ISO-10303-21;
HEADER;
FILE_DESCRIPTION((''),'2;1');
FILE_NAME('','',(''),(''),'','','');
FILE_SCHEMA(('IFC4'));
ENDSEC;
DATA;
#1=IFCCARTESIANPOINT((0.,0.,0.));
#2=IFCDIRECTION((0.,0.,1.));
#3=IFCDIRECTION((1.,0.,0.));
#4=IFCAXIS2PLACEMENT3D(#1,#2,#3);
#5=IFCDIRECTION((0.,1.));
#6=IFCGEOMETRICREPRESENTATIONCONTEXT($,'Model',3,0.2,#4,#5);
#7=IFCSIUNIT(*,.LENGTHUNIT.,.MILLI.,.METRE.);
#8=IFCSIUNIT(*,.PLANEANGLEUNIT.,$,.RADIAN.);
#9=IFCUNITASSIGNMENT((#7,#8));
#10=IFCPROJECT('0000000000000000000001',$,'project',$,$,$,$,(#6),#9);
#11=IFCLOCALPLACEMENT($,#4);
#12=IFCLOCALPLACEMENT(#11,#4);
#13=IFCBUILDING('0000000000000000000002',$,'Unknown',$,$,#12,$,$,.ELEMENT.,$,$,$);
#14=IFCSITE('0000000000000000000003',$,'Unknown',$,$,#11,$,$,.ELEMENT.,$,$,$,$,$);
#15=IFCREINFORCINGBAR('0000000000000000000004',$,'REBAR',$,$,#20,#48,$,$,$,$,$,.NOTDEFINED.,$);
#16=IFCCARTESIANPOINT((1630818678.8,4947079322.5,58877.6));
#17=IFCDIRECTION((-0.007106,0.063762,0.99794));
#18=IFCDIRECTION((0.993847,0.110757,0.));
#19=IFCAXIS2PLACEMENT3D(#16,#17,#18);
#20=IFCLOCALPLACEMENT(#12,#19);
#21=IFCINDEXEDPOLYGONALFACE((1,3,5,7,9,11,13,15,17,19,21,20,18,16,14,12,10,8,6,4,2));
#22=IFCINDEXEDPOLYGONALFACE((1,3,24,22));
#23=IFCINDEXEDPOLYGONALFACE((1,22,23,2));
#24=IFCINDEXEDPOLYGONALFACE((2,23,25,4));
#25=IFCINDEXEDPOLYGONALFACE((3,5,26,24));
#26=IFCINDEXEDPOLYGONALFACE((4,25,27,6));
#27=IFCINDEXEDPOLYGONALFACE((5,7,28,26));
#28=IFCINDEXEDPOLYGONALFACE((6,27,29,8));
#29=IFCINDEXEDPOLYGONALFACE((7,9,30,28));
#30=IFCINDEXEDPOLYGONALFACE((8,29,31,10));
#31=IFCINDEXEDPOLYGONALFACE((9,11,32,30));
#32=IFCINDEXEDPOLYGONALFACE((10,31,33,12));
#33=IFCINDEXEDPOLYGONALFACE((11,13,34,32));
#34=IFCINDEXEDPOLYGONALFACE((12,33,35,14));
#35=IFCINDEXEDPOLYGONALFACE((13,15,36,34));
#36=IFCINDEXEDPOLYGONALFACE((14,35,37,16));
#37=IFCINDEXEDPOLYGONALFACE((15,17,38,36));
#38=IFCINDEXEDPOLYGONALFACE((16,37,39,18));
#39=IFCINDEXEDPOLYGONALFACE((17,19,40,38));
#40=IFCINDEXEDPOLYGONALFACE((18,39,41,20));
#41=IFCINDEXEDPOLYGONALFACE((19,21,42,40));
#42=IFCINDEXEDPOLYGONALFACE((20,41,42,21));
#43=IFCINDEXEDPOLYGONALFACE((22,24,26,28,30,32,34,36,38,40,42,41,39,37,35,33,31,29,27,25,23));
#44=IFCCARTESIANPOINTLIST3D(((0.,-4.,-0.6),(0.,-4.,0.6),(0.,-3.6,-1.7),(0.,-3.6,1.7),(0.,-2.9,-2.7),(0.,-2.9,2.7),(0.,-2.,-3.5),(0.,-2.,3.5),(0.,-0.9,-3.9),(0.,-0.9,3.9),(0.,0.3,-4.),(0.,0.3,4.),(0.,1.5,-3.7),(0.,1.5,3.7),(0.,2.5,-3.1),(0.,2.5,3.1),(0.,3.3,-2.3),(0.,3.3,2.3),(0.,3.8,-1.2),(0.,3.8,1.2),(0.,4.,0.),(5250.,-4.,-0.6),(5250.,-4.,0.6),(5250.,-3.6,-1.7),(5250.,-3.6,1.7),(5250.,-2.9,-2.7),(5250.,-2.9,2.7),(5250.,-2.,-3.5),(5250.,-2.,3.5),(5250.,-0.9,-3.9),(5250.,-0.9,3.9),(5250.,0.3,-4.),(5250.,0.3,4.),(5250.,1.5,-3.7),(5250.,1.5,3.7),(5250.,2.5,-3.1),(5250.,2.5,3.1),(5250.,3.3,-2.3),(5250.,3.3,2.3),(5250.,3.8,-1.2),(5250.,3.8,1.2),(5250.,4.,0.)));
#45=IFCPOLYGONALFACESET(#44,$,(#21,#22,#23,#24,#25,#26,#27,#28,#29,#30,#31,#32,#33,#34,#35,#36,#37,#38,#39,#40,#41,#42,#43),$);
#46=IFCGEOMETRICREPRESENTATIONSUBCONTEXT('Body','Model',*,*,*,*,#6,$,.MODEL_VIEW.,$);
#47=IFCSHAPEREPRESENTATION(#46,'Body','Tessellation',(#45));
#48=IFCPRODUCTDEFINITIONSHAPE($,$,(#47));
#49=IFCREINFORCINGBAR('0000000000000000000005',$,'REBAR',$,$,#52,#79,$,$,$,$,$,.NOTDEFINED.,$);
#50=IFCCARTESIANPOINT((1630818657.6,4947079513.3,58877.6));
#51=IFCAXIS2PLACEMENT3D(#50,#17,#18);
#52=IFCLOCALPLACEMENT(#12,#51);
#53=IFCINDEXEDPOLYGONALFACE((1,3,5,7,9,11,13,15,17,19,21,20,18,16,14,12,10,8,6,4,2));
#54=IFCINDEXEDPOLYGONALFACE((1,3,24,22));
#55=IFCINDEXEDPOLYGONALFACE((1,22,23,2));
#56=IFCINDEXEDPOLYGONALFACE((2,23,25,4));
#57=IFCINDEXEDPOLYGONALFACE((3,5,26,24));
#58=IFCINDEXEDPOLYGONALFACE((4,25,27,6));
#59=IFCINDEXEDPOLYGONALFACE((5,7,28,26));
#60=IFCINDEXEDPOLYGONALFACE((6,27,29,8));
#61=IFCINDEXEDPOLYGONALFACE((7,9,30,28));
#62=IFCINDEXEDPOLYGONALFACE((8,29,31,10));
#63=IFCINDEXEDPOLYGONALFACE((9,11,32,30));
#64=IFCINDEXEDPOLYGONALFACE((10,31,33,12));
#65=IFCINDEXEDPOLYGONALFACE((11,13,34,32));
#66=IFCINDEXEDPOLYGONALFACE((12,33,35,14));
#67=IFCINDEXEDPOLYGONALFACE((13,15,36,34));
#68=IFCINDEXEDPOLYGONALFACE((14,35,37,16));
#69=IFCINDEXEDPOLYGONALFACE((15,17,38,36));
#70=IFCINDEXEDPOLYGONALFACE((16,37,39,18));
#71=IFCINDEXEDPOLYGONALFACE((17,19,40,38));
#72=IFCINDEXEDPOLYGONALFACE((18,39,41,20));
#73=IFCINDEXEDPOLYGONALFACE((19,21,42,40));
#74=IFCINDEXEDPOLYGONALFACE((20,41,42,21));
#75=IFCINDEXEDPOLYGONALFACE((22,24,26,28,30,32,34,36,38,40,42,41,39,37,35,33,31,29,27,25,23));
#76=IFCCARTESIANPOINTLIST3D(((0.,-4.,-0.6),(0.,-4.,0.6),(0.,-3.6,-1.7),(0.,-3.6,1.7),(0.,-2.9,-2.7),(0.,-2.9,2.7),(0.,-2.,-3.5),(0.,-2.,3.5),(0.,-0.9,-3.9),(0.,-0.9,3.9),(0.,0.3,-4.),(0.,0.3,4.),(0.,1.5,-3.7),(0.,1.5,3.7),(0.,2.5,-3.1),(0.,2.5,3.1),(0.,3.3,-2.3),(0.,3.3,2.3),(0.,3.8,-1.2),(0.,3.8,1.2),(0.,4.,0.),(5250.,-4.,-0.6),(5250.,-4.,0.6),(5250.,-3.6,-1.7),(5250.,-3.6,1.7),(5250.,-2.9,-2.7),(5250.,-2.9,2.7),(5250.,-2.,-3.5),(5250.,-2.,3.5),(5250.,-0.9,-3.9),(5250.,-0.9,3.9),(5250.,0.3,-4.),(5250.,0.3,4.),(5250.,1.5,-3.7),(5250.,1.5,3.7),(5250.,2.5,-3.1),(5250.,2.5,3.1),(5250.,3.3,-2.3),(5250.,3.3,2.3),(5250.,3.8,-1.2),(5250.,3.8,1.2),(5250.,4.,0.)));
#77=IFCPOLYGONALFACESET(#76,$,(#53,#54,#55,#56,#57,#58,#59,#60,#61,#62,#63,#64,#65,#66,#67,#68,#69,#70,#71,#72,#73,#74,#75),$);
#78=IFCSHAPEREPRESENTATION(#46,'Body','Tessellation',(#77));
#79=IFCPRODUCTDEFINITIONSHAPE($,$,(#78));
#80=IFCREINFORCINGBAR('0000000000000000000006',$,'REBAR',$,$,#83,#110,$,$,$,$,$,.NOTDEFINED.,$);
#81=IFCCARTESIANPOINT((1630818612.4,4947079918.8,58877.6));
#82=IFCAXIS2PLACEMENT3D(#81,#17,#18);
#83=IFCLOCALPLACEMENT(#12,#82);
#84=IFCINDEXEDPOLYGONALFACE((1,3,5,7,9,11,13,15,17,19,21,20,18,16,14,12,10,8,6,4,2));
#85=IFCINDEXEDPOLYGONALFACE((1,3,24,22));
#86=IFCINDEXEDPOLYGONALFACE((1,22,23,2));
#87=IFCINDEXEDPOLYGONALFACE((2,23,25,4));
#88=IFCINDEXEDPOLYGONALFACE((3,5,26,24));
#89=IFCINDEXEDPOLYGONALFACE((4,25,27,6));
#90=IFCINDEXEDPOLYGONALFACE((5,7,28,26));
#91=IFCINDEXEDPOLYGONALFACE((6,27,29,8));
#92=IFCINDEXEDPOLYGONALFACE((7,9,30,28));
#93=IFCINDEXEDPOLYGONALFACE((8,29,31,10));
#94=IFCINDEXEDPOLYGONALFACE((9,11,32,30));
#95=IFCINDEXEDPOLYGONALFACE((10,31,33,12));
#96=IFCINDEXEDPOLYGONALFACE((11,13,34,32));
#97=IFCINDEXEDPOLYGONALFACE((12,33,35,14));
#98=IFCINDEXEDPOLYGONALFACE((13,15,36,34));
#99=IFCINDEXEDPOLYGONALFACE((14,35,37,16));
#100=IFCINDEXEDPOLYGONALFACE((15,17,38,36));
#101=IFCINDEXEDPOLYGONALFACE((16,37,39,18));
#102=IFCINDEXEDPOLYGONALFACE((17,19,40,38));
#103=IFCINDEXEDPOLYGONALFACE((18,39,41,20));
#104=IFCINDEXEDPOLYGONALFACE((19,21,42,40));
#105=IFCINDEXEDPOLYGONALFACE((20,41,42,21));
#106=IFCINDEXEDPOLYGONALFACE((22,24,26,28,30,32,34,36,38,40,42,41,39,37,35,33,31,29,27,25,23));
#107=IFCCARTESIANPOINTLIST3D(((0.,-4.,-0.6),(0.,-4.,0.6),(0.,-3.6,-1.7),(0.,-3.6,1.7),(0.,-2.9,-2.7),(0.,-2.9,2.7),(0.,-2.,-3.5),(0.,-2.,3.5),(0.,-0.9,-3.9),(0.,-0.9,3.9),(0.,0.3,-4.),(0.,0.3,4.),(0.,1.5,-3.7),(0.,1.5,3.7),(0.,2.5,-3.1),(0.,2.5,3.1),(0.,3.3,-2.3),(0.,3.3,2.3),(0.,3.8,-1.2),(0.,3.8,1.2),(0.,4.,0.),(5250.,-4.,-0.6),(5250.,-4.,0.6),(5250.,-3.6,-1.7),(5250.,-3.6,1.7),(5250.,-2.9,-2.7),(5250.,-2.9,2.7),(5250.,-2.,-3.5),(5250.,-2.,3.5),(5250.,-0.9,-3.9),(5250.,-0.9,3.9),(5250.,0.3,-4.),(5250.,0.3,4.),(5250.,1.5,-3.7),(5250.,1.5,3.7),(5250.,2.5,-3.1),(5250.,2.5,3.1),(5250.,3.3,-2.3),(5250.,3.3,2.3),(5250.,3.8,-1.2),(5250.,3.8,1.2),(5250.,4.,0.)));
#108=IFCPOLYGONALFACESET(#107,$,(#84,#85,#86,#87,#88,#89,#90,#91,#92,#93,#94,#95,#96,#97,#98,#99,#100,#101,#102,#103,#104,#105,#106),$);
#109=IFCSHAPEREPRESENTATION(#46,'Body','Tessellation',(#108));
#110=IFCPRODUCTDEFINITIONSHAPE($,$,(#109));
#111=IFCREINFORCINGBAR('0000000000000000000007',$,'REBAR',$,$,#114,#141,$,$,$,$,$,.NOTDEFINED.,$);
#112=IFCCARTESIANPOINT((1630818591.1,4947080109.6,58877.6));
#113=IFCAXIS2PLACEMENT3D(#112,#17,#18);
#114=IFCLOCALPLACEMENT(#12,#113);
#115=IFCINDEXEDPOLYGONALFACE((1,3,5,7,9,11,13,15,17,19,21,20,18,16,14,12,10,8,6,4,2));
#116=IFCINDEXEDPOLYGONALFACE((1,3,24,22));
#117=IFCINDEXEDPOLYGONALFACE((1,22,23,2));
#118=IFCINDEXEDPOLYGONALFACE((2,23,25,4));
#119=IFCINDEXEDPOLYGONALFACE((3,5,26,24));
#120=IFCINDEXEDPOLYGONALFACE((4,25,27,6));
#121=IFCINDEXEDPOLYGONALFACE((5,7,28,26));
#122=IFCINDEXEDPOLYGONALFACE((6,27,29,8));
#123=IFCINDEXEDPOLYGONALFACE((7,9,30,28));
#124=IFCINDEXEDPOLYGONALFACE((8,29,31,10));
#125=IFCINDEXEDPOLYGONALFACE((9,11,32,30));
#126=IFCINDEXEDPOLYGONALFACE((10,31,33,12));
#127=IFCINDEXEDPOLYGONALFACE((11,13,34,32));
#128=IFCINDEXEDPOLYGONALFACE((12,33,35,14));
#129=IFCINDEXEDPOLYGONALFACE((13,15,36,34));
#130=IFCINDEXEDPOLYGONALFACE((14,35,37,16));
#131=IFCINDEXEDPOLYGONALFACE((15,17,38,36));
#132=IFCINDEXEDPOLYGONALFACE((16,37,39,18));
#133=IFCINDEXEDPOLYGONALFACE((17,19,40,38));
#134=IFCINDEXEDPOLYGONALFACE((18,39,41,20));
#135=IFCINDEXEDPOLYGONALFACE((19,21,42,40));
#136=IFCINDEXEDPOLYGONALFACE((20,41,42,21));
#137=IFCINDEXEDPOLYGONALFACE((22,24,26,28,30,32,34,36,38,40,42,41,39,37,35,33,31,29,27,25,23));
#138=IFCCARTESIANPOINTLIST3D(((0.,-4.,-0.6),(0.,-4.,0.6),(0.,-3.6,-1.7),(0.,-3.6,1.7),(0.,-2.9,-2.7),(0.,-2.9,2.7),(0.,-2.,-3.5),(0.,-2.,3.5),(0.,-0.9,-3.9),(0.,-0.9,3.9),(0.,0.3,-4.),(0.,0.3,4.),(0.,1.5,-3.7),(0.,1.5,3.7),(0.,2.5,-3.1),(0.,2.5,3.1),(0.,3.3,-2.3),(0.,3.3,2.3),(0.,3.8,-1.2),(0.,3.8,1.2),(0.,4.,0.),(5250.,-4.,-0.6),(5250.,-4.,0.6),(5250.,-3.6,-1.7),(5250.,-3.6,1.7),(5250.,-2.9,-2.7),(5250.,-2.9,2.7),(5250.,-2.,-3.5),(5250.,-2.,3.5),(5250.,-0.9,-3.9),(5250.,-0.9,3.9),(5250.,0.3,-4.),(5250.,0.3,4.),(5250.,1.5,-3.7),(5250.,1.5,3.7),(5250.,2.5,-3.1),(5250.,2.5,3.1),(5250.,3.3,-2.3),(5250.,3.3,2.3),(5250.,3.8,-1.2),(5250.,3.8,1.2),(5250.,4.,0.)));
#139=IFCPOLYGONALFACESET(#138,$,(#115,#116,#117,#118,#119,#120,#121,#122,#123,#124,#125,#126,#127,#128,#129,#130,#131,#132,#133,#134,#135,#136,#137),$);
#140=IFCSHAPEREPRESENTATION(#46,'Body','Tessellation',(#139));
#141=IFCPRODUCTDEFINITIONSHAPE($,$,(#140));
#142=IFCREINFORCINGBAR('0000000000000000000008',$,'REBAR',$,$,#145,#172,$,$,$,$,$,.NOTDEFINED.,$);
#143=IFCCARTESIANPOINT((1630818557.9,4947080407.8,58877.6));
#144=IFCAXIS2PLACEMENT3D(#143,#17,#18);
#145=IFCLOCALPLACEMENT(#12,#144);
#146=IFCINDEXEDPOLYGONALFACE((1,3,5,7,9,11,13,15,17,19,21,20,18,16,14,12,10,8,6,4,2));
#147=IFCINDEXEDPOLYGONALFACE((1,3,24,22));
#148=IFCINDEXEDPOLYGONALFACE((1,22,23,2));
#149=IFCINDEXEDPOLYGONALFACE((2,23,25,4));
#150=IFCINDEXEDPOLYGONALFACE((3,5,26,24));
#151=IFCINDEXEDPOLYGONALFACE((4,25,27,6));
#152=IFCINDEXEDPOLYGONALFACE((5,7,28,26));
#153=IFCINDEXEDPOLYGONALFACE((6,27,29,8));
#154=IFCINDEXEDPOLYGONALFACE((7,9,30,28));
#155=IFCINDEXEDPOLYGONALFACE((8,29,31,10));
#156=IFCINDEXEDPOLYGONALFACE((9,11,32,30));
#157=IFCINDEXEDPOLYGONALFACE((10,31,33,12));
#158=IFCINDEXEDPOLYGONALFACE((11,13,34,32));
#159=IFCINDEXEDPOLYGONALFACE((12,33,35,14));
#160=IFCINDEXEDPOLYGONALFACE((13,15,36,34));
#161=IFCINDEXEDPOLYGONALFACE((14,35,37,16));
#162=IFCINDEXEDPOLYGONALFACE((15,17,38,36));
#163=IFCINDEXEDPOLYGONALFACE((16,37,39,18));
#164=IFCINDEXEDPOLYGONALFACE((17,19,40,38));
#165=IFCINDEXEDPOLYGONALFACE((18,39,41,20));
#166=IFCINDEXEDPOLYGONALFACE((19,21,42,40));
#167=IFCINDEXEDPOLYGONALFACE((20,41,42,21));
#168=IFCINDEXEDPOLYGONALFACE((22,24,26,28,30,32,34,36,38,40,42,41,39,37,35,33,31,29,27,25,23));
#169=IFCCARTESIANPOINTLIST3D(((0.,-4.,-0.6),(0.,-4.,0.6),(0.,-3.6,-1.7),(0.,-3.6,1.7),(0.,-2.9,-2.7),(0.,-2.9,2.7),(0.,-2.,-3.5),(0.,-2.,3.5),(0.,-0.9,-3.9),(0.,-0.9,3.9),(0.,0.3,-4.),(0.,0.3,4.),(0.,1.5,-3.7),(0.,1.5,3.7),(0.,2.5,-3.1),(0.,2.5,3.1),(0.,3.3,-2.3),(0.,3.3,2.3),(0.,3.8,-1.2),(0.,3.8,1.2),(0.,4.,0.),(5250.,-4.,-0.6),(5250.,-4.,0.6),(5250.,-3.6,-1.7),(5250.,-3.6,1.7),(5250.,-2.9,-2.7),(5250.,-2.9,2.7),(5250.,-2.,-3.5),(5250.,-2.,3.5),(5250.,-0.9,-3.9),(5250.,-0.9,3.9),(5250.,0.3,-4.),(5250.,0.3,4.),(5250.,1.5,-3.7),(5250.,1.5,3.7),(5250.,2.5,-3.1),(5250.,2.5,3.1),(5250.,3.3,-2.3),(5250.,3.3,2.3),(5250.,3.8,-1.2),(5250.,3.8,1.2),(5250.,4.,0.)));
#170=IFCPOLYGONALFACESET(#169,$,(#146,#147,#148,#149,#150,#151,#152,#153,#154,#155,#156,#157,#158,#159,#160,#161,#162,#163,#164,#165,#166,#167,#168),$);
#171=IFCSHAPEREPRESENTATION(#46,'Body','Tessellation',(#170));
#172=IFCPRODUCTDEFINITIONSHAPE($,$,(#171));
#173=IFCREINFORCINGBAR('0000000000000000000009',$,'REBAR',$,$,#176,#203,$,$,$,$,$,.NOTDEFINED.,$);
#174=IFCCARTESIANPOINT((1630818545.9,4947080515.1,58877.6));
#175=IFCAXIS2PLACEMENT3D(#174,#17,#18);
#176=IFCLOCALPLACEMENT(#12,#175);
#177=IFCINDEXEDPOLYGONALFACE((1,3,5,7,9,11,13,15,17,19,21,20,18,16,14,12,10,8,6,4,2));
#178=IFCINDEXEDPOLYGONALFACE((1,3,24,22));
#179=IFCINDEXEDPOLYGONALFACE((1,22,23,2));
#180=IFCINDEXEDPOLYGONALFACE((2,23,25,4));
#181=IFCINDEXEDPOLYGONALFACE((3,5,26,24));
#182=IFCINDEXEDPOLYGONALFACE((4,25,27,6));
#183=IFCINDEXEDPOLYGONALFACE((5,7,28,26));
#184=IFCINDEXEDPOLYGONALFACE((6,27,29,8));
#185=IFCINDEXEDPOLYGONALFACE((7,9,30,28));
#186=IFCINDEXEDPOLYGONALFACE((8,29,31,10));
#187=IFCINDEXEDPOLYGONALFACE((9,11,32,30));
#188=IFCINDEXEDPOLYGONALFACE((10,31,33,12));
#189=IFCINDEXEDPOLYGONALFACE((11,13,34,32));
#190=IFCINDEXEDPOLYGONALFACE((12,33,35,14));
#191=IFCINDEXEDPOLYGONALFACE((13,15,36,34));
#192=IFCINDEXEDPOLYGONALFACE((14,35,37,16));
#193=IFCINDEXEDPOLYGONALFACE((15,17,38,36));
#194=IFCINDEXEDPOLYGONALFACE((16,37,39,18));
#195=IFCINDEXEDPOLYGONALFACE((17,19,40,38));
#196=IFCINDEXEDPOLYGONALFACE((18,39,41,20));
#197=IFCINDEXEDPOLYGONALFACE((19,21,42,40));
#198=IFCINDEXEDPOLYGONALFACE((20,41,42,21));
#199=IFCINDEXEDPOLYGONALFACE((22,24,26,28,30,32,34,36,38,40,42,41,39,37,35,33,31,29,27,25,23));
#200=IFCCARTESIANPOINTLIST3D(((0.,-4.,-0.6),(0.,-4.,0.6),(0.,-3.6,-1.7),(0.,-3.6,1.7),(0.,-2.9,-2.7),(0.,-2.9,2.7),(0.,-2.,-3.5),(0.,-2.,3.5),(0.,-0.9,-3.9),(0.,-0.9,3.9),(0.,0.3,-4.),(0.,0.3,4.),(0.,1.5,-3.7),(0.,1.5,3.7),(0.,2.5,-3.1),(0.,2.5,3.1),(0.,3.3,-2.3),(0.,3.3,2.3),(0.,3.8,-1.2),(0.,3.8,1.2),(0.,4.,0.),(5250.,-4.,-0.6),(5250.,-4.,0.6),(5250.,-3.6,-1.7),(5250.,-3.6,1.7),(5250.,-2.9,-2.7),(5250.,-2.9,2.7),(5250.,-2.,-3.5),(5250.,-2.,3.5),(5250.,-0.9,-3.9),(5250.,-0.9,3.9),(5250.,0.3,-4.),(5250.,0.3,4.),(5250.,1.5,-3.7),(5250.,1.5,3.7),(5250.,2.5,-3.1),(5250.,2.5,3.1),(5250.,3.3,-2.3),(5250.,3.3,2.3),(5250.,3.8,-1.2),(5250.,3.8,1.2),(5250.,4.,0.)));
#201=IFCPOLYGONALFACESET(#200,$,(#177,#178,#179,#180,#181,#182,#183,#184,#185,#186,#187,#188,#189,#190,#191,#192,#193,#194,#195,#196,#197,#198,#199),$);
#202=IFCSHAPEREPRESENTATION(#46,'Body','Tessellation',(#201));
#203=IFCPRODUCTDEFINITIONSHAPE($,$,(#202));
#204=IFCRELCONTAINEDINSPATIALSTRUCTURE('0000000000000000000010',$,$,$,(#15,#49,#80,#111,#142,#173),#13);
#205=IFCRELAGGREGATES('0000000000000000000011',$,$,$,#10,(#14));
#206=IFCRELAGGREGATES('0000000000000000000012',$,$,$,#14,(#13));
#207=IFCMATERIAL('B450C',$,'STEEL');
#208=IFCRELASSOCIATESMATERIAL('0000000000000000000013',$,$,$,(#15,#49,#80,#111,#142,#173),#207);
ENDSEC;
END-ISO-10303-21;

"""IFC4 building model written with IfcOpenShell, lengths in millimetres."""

from ifc_helpers import new_model, entity, si_unit, direction, frame, origin_with_axes, place, context, subcontext, project, spatial, material, element, save


model = new_model("IFC4")

# Units and contexts
model_context = context("Model", 3, precision=0.2, world=origin_with_axes(), true_north=direction((0.0, 1.0)))
body_context = subcontext(model_context, "Body", "Model", "MODEL_VIEW")
ifc_project = project(units=[si_unit("LENGTHUNIT", "METRE", prefix="MILLI"), si_unit("PLANEANGLEUNIT", "RADIAN")], contexts=[model_context])

# Site, building
site_placement = place(None, origin_with_axes())
site = spatial("IfcSite", under=ifc_project, at=site_placement, Name="Unknown", CompositionType="ELEMENT")
building_placement = place(site_placement, origin_with_axes())
building = spatial("IfcBuilding", under=site, at=building_placement, Name="Unknown", CompositionType="ELEMENT")

# Reinforcing bars
ifc_material = material(Name="B450C", Category="STEEL")
for number, where, z_axis, x_axis, name in (
    (1, (1630818678.8, 4947079322.5, 58877.6), (-0.007106, 0.063762, 0.99794), (0.993847, 0.110757, 0.0), "REBAR"),
    (2, (1630818657.6, 4947079513.3, 58877.6), (-0.007106, 0.063762, 0.99794), (0.993847, 0.110757, 0.0), "REBAR"),
):
    element("IfcReinforcingBar", number, at=place(building_placement, frame(where, z_axis=z_axis, x_axis=x_axis)), inside=building, material=ifc_material, Name=name, PredefinedType="NOTDEFINED", context=body_context, shape_type="AdvancedSweptSolid", body=[
        entity("IfcSweptDiskSolid", entity("IfcIndexedPolyCurve", entity("IfcCartesianPointList3D", [[0.0, 0.0, 0.0], [5250.0, 0.0, 0.0]]), [entity("IfcLineIndex", [1, 2])]), 4.0),
    ])
for number, where, z_axis, x_axis, name in (
    (3, (1630818612.4, 4947079918.8, 58877.6), (-0.007106, 0.063762, 0.99794), (0.993847, 0.110757, 0.0), "REBAR"),
    (4, (1630818591.1, 4947080109.6, 58877.6), (-0.007106, 0.063762, 0.99794), (0.993847, 0.110757, 0.0), "REBAR"),
    (5, (1630818557.9, 4947080407.8, 58877.6), (-0.007106, 0.063762, 0.99794), (0.993847, 0.110757, 0.0), "REBAR"),
    (6, (1630818545.9, 4947080515.1, 58877.6), (-0.007106, 0.063762, 0.99794), (0.993847, 0.110757, 0.0), "REBAR"),
):
    element("IfcReinforcingBar", number, at=place(building_placement, frame(where, z_axis=z_axis, x_axis=x_axis)), inside=building, material=ifc_material, Name=name, PredefinedType="NOTDEFINED", context=body_context, shape_type="AdvancedSweptSolid", body=[
        entity("IfcSweptDiskSolid", entity("IfcIndexedPolyCurve", entity("IfcCartesianPointList3D", [[0.0, 0.0, 0.0], [5250.0, 0.0, 0.0]]), [entity("IfcLineIndex", [1, 2])]), 4.0),
    ])

save(model, "model.ifc")
